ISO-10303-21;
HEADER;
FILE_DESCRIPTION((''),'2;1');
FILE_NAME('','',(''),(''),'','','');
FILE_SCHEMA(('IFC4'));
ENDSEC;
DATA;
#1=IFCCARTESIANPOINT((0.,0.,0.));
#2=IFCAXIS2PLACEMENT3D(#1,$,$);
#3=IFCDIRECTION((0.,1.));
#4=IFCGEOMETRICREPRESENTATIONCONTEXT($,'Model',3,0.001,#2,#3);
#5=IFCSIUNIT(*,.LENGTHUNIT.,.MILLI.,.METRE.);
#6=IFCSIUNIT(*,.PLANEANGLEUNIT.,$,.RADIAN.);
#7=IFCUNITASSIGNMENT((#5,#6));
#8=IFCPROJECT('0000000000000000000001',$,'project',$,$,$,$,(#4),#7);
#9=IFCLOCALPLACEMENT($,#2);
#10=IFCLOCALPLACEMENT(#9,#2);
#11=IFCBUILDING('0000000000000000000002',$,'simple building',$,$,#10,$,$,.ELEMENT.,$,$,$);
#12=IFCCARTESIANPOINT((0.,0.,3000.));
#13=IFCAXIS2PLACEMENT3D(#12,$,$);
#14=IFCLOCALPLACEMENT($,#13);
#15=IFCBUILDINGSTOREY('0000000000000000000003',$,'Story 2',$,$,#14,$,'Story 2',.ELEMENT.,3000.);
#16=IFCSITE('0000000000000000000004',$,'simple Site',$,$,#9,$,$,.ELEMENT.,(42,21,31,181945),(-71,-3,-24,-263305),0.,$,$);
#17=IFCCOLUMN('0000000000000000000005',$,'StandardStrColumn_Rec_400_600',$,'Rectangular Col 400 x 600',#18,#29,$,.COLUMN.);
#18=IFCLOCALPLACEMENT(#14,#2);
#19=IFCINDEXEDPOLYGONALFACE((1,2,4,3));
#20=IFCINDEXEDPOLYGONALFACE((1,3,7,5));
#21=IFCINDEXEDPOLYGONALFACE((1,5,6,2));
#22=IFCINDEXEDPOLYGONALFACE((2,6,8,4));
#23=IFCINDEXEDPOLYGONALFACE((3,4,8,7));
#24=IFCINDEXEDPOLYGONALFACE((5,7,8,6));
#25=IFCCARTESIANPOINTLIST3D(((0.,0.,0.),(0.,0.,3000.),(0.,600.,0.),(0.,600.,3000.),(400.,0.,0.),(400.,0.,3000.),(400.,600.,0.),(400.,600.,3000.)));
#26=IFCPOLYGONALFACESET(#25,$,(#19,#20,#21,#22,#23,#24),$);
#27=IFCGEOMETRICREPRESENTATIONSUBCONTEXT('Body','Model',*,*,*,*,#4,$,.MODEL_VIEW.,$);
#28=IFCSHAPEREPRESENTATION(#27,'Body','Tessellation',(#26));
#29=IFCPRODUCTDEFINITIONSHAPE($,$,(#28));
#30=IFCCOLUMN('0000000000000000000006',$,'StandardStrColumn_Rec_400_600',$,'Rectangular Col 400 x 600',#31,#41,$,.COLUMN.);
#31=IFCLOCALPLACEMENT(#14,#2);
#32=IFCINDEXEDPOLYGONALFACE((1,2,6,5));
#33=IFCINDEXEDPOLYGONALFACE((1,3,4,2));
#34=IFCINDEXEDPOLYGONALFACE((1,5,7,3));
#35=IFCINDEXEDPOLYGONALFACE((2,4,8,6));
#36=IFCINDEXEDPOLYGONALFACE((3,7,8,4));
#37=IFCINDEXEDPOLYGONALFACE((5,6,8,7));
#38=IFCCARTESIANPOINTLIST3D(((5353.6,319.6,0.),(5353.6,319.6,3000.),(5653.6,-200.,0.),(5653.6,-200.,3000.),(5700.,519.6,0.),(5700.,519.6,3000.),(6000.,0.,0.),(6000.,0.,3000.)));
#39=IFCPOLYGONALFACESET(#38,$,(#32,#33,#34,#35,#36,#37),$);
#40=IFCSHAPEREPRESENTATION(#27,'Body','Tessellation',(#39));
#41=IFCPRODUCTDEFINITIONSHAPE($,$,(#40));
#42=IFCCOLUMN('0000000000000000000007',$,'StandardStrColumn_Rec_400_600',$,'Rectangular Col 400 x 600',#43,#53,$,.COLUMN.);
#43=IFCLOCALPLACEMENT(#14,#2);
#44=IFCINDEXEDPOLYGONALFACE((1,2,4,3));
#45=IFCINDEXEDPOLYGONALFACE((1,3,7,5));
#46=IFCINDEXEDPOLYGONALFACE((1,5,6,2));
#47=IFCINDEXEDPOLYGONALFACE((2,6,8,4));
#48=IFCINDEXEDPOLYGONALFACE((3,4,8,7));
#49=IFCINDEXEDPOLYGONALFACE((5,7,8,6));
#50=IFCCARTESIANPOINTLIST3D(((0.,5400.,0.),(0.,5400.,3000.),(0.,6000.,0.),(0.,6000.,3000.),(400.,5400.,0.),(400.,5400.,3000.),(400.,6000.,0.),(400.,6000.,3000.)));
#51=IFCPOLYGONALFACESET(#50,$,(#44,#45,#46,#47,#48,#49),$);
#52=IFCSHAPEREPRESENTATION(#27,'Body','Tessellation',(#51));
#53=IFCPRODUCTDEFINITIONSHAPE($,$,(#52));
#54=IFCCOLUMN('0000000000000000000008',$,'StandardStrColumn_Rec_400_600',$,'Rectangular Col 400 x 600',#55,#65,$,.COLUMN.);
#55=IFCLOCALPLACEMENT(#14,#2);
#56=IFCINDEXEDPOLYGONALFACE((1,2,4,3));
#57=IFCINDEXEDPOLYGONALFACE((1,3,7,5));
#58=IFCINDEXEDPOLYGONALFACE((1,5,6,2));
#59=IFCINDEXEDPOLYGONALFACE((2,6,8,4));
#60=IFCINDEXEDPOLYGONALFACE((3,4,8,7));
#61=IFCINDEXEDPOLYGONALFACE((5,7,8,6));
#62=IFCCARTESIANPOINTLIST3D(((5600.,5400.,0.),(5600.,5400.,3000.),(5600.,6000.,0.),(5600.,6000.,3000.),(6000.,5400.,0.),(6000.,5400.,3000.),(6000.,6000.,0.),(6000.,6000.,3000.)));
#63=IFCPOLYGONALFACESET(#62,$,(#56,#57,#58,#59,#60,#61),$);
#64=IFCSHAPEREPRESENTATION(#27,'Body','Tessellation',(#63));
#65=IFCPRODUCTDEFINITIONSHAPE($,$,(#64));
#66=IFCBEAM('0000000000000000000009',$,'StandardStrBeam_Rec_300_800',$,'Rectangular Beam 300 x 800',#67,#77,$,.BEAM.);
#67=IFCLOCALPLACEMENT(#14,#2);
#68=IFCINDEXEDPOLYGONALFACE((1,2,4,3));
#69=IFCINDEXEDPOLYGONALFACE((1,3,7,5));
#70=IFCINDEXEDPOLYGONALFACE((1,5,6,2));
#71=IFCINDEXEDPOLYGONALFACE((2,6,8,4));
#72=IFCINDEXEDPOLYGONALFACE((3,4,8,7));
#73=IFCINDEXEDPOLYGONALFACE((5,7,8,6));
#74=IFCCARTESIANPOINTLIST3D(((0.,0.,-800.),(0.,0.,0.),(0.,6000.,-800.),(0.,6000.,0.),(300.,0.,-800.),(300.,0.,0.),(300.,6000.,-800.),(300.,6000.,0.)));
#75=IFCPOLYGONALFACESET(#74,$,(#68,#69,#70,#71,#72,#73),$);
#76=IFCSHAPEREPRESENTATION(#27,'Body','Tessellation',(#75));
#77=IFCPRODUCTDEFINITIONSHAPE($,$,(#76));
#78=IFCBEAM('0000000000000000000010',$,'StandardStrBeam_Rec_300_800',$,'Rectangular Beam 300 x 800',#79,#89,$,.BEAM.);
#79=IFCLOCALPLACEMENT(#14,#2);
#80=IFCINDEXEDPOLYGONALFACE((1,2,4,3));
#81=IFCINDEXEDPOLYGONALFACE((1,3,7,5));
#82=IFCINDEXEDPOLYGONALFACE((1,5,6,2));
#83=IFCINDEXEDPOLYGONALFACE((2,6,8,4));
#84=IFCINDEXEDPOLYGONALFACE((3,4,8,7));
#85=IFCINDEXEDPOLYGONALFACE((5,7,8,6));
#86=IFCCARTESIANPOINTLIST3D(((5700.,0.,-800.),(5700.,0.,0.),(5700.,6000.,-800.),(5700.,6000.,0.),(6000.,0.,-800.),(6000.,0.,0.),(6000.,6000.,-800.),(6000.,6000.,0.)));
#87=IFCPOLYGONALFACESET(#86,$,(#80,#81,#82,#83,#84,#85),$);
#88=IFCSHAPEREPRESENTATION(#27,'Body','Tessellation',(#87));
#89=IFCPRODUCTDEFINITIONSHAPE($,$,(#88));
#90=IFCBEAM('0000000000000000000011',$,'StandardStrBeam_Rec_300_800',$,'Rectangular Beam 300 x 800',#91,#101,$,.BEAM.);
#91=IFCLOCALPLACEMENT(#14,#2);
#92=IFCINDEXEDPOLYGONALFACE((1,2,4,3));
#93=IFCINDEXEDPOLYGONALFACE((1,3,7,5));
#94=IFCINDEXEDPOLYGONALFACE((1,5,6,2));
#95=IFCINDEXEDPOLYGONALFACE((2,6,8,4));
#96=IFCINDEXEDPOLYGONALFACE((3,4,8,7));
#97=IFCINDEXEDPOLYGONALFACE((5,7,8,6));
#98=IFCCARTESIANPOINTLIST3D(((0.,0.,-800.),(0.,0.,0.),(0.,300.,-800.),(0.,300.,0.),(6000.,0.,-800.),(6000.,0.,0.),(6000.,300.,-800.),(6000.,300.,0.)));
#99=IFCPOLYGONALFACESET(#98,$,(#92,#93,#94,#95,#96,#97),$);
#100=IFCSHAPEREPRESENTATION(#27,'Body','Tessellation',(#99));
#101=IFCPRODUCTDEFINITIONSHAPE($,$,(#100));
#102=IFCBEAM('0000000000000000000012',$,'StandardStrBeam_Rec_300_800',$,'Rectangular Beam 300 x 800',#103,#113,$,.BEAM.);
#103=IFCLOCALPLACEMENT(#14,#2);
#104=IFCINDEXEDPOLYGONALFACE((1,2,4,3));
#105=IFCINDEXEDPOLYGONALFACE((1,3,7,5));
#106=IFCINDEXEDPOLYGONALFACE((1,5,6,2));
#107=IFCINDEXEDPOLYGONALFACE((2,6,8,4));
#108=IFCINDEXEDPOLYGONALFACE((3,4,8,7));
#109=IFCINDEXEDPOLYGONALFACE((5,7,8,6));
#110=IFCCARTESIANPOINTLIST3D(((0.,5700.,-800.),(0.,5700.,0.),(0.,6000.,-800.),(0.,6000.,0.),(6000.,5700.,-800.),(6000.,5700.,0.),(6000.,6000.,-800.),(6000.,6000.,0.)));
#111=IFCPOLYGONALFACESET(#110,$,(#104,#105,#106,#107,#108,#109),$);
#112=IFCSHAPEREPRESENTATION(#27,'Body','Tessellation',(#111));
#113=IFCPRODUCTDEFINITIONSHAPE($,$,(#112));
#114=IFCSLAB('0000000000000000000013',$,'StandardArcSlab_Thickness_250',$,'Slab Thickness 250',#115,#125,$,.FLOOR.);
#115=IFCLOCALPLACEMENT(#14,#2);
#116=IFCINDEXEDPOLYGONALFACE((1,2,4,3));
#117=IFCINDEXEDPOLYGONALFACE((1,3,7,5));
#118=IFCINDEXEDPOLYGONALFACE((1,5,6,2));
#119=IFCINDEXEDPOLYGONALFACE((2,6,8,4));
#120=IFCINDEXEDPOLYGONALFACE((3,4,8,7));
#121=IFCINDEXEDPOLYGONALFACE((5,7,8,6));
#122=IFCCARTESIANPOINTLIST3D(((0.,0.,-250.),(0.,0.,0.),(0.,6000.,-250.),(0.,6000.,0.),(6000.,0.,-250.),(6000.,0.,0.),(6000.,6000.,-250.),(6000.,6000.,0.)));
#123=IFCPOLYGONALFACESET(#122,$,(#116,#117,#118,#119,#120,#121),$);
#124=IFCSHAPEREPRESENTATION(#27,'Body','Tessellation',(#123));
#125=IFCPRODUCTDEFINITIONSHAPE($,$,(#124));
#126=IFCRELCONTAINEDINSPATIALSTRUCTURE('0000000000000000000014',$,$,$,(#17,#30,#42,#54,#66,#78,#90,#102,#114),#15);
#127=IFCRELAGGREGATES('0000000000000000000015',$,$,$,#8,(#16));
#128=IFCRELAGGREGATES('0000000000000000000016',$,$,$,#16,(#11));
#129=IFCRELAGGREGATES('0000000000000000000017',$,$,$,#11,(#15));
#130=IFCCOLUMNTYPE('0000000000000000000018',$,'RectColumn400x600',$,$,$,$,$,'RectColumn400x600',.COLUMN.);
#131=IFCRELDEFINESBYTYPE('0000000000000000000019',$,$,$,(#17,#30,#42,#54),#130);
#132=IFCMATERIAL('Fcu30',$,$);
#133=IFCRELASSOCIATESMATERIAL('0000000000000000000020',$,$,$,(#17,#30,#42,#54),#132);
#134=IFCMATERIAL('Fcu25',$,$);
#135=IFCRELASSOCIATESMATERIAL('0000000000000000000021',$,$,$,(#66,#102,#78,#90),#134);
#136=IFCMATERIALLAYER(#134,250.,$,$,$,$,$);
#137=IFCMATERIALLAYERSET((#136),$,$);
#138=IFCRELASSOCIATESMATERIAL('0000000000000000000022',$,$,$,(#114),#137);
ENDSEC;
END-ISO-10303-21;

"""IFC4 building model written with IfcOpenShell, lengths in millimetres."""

from ifc_helpers import new_model, si_unit, direction, frame, origin, origin_with_axes, origin_2d_with_axis, place, context, subcontext, project, spatial, polyline, rectangle, outline, extrude, material, layer, layer_set, layer_usage, material_profile, profile_set, profile_usage, type_object, element, save


model = new_model("IFC4")

# Units and contexts
model_context = context("Model", 3, precision=0.001, world=origin(), true_north=direction((0.0, 1.0)))
body_context = subcontext(model_context, "Body", "Model", "MODEL_VIEW")
ifc_project = project(units=[si_unit("LENGTHUNIT", "METRE", prefix="MILLI"), si_unit("PLANEANGLEUNIT", "RADIAN")], contexts=[model_context])

# Site, building, storey
site_placement = place(None, origin())
site = spatial("IfcSite", under=ifc_project, at=site_placement, Name="simple Site", CompositionType="ELEMENT", RefLatitude=(42, 21, 31, 181945), RefLongitude=(-71, -3, -24, -263305), RefElevation=0.0)
building_placement = place(site_placement, origin())
building = spatial("IfcBuilding", under=site, at=building_placement, Name="simple building", CompositionType="ELEMENT")
storey_placement = place(None, frame((0.0, 0.0, 3000.0)))
storey = spatial("IfcBuildingStorey", under=building, at=storey_placement, Name="Story 2", LongName="Story 2", CompositionType="ELEMENT", Elevation=3000.0)

# Columns
ifc_material_1 = material(Name="Fcu30")
ifc_material_profile_1 = material_profile(ifc_material_1, rectangle(XDim=400.0, YDim=600.0, at=origin_2d_with_axis()))
ifc_profile_set_1 = profile_set([ifc_material_profile_1])
ifc_profile_usage_1 = profile_usage(ifc_profile_set_1, cardinal=7)
column_type = type_object("IfcColumnType", Name="RectColumn400x600", ElementType="RectColumn400x600", PredefinedType="COLUMN")
column_1_placement = place(None, frame((200.0, 300.0, 3000.0), z_axis=(0.0, 0.0, 1.0), x_axis=(1.0, 0.0, 0.0)))
element("IfcColumn", 1, at=column_1_placement, inside=storey, type_object=column_type, material=ifc_profile_usage_1, Name="StandardStrColumn_Rec_400_600", ObjectType="Rectangular Col 400 x 600", PredefinedType="COLUMN", context=body_context, shape_type="SweptSolid", body=[
    extrude(rectangle(XDim=400.0, YDim=600.0, at=origin_2d_with_axis()), origin_with_axes(), (0.0, 0.0, 1.0), 3000.0),
])
ifc_profile_usage_2 = profile_usage(ifc_profile_set_1, cardinal=9)
column_2_placement = place(None, frame((5676.8, 159.8, 3000.0), z_axis=(0.0, 0.0, 1.0), x_axis=(0.866025, 0.5, 0.0)))
element("IfcColumn", 2, at=column_2_placement, inside=storey, type_object=column_type, material=ifc_profile_usage_2, Name="StandardStrColumn_Rec_400_600", ObjectType="Rectangular Col 400 x 600", PredefinedType="COLUMN", context=body_context, shape_type="SweptSolid", body=[
    extrude(rectangle(XDim=400.0, YDim=600.0, at=origin_2d_with_axis()), origin_with_axes(), (0.0, 0.0, 1.0), 3000.0),
])
ifc_profile_usage_3 = profile_usage(ifc_profile_set_1, cardinal=1)
column_3_placement = place(None, frame((200.0, 5700.0, 3000.0), z_axis=(0.0, 0.0, 1.0), x_axis=(1.0, 0.0, 0.0)))
element("IfcColumn", 3, at=column_3_placement, inside=storey, type_object=column_type, material=ifc_profile_usage_3, Name="StandardStrColumn_Rec_400_600", ObjectType="Rectangular Col 400 x 600", PredefinedType="COLUMN", context=body_context, shape_type="SweptSolid", body=[
    extrude(rectangle(XDim=400.0, YDim=600.0, at=origin_2d_with_axis()), origin_with_axes(), (0.0, 0.0, 1.0), 3000.0),
])
ifc_profile_usage_4 = profile_usage(ifc_profile_set_1, cardinal=3)
column_4_placement = place(None, frame((5800.0, 5700.0, 3000.0), z_axis=(0.0, 0.0, 1.0), x_axis=(1.0, 0.0, 0.0)))
element("IfcColumn", 4, at=column_4_placement, inside=storey, type_object=column_type, material=ifc_profile_usage_4, Name="StandardStrColumn_Rec_400_600", ObjectType="Rectangular Col 400 x 600", PredefinedType="COLUMN", context=body_context, shape_type="SweptSolid", body=[
    extrude(rectangle(XDim=400.0, YDim=600.0, at=origin_2d_with_axis()), origin_with_axes(), (0.0, 0.0, 1.0), 3000.0),
])

# Beams
ifc_material_2 = material(Name="Fcu25")
ifc_material_profile_2 = material_profile(ifc_material_2, rectangle(XDim=300.0, YDim=800.0, at=origin_2d_with_axis()))
ifc_profile_set_2 = profile_set([ifc_material_profile_2])
ifc_profile_usage_5 = profile_usage(ifc_profile_set_2, cardinal=7)
beam_1_placement = place(None, frame((150.0, 0.0, 2600.0), z_axis=(0.0, 1.0, 0.0), x_axis=(1.0, 0.0, 0.0)))
element("IfcBeam", 5, at=beam_1_placement, inside=storey, material=ifc_profile_usage_5, Name="StandardStrBeam_Rec_300_800", ObjectType="Rectangular Beam 300 x 800", PredefinedType="BEAM", context=body_context, shape_type="SweptSolid", body=[
    extrude(rectangle(XDim=300.0, YDim=800.0, at=origin_2d_with_axis()), origin_with_axes(), (0.0, 0.0, 1.0), 6000.0),
])
ifc_profile_usage_6 = profile_usage(ifc_profile_set_2, cardinal=9)
for number, where, z_axis, x_axis, name in (
    (6, (5850.0, 0.0, 2600.0), (0.0, 1.0, 0.0), (1.0, 0.0, 0.0), "StandardStrBeam_Rec_300_800"),
    (7, (0.0, 150.0, 2600.0), (1.0, 0.0, 0.0), (0.0, -1.0, 0.0), "StandardStrBeam_Rec_300_800"),
):
    element("IfcBeam", number, at=place(None, frame(where, z_axis=z_axis, x_axis=x_axis)), inside=storey, material=ifc_profile_usage_6, Name=name, ObjectType="Rectangular Beam 300 x 800", PredefinedType="BEAM", context=body_context, shape_type="SweptSolid", body=[
        extrude(rectangle(XDim=300.0, YDim=800.0, at=origin_2d_with_axis()), origin_with_axes(), (0.0, 0.0, 1.0), 6000.0),
    ])
beam_2_placement = place(None, frame((0.0, 5850.0, 2600.0), z_axis=(1.0, 0.0, 0.0), x_axis=(0.0, -1.0, 0.0)))
element("IfcBeam", 8, at=beam_2_placement, inside=storey, material=ifc_profile_usage_5, Name="StandardStrBeam_Rec_300_800", ObjectType="Rectangular Beam 300 x 800", PredefinedType="BEAM", context=body_context, shape_type="SweptSolid", body=[
    extrude(rectangle(XDim=300.0, YDim=800.0, at=origin_2d_with_axis()), origin_with_axes(), (0.0, 0.0, 1.0), 6000.0),
])

# Slab
ifc_layer = layer(ifc_material_2, 250.0)
ifc_layer_set = layer_set([ifc_layer])
ifc_layer_usage = layer_usage(ifc_layer_set, "AXIS3", "POSITIVE", -250.0)
slab_placement = place(None, frame((0.0, 0.0, 2750.0), z_axis=(0.0, 0.0, 1.0), x_axis=(1.0, 0.0, 0.0)))
element("IfcSlab", 9, at=slab_placement, inside=storey, material=ifc_layer_usage, Name="StandardArcSlab_Thickness_250", ObjectType="Slab Thickness 250", PredefinedType="FLOOR", context=body_context, shape_type="SweptSolid", body=[
    extrude(outline(polyline([(0.0, 0.0), (6000.0, 0.0), (6000.0, 6000.0), (0.0, 6000.0), (0.0, 0.0)])), origin_with_axes(), (0.0, 0.0, 1.0), 250.0),
])

save(model, "model.ifc")
